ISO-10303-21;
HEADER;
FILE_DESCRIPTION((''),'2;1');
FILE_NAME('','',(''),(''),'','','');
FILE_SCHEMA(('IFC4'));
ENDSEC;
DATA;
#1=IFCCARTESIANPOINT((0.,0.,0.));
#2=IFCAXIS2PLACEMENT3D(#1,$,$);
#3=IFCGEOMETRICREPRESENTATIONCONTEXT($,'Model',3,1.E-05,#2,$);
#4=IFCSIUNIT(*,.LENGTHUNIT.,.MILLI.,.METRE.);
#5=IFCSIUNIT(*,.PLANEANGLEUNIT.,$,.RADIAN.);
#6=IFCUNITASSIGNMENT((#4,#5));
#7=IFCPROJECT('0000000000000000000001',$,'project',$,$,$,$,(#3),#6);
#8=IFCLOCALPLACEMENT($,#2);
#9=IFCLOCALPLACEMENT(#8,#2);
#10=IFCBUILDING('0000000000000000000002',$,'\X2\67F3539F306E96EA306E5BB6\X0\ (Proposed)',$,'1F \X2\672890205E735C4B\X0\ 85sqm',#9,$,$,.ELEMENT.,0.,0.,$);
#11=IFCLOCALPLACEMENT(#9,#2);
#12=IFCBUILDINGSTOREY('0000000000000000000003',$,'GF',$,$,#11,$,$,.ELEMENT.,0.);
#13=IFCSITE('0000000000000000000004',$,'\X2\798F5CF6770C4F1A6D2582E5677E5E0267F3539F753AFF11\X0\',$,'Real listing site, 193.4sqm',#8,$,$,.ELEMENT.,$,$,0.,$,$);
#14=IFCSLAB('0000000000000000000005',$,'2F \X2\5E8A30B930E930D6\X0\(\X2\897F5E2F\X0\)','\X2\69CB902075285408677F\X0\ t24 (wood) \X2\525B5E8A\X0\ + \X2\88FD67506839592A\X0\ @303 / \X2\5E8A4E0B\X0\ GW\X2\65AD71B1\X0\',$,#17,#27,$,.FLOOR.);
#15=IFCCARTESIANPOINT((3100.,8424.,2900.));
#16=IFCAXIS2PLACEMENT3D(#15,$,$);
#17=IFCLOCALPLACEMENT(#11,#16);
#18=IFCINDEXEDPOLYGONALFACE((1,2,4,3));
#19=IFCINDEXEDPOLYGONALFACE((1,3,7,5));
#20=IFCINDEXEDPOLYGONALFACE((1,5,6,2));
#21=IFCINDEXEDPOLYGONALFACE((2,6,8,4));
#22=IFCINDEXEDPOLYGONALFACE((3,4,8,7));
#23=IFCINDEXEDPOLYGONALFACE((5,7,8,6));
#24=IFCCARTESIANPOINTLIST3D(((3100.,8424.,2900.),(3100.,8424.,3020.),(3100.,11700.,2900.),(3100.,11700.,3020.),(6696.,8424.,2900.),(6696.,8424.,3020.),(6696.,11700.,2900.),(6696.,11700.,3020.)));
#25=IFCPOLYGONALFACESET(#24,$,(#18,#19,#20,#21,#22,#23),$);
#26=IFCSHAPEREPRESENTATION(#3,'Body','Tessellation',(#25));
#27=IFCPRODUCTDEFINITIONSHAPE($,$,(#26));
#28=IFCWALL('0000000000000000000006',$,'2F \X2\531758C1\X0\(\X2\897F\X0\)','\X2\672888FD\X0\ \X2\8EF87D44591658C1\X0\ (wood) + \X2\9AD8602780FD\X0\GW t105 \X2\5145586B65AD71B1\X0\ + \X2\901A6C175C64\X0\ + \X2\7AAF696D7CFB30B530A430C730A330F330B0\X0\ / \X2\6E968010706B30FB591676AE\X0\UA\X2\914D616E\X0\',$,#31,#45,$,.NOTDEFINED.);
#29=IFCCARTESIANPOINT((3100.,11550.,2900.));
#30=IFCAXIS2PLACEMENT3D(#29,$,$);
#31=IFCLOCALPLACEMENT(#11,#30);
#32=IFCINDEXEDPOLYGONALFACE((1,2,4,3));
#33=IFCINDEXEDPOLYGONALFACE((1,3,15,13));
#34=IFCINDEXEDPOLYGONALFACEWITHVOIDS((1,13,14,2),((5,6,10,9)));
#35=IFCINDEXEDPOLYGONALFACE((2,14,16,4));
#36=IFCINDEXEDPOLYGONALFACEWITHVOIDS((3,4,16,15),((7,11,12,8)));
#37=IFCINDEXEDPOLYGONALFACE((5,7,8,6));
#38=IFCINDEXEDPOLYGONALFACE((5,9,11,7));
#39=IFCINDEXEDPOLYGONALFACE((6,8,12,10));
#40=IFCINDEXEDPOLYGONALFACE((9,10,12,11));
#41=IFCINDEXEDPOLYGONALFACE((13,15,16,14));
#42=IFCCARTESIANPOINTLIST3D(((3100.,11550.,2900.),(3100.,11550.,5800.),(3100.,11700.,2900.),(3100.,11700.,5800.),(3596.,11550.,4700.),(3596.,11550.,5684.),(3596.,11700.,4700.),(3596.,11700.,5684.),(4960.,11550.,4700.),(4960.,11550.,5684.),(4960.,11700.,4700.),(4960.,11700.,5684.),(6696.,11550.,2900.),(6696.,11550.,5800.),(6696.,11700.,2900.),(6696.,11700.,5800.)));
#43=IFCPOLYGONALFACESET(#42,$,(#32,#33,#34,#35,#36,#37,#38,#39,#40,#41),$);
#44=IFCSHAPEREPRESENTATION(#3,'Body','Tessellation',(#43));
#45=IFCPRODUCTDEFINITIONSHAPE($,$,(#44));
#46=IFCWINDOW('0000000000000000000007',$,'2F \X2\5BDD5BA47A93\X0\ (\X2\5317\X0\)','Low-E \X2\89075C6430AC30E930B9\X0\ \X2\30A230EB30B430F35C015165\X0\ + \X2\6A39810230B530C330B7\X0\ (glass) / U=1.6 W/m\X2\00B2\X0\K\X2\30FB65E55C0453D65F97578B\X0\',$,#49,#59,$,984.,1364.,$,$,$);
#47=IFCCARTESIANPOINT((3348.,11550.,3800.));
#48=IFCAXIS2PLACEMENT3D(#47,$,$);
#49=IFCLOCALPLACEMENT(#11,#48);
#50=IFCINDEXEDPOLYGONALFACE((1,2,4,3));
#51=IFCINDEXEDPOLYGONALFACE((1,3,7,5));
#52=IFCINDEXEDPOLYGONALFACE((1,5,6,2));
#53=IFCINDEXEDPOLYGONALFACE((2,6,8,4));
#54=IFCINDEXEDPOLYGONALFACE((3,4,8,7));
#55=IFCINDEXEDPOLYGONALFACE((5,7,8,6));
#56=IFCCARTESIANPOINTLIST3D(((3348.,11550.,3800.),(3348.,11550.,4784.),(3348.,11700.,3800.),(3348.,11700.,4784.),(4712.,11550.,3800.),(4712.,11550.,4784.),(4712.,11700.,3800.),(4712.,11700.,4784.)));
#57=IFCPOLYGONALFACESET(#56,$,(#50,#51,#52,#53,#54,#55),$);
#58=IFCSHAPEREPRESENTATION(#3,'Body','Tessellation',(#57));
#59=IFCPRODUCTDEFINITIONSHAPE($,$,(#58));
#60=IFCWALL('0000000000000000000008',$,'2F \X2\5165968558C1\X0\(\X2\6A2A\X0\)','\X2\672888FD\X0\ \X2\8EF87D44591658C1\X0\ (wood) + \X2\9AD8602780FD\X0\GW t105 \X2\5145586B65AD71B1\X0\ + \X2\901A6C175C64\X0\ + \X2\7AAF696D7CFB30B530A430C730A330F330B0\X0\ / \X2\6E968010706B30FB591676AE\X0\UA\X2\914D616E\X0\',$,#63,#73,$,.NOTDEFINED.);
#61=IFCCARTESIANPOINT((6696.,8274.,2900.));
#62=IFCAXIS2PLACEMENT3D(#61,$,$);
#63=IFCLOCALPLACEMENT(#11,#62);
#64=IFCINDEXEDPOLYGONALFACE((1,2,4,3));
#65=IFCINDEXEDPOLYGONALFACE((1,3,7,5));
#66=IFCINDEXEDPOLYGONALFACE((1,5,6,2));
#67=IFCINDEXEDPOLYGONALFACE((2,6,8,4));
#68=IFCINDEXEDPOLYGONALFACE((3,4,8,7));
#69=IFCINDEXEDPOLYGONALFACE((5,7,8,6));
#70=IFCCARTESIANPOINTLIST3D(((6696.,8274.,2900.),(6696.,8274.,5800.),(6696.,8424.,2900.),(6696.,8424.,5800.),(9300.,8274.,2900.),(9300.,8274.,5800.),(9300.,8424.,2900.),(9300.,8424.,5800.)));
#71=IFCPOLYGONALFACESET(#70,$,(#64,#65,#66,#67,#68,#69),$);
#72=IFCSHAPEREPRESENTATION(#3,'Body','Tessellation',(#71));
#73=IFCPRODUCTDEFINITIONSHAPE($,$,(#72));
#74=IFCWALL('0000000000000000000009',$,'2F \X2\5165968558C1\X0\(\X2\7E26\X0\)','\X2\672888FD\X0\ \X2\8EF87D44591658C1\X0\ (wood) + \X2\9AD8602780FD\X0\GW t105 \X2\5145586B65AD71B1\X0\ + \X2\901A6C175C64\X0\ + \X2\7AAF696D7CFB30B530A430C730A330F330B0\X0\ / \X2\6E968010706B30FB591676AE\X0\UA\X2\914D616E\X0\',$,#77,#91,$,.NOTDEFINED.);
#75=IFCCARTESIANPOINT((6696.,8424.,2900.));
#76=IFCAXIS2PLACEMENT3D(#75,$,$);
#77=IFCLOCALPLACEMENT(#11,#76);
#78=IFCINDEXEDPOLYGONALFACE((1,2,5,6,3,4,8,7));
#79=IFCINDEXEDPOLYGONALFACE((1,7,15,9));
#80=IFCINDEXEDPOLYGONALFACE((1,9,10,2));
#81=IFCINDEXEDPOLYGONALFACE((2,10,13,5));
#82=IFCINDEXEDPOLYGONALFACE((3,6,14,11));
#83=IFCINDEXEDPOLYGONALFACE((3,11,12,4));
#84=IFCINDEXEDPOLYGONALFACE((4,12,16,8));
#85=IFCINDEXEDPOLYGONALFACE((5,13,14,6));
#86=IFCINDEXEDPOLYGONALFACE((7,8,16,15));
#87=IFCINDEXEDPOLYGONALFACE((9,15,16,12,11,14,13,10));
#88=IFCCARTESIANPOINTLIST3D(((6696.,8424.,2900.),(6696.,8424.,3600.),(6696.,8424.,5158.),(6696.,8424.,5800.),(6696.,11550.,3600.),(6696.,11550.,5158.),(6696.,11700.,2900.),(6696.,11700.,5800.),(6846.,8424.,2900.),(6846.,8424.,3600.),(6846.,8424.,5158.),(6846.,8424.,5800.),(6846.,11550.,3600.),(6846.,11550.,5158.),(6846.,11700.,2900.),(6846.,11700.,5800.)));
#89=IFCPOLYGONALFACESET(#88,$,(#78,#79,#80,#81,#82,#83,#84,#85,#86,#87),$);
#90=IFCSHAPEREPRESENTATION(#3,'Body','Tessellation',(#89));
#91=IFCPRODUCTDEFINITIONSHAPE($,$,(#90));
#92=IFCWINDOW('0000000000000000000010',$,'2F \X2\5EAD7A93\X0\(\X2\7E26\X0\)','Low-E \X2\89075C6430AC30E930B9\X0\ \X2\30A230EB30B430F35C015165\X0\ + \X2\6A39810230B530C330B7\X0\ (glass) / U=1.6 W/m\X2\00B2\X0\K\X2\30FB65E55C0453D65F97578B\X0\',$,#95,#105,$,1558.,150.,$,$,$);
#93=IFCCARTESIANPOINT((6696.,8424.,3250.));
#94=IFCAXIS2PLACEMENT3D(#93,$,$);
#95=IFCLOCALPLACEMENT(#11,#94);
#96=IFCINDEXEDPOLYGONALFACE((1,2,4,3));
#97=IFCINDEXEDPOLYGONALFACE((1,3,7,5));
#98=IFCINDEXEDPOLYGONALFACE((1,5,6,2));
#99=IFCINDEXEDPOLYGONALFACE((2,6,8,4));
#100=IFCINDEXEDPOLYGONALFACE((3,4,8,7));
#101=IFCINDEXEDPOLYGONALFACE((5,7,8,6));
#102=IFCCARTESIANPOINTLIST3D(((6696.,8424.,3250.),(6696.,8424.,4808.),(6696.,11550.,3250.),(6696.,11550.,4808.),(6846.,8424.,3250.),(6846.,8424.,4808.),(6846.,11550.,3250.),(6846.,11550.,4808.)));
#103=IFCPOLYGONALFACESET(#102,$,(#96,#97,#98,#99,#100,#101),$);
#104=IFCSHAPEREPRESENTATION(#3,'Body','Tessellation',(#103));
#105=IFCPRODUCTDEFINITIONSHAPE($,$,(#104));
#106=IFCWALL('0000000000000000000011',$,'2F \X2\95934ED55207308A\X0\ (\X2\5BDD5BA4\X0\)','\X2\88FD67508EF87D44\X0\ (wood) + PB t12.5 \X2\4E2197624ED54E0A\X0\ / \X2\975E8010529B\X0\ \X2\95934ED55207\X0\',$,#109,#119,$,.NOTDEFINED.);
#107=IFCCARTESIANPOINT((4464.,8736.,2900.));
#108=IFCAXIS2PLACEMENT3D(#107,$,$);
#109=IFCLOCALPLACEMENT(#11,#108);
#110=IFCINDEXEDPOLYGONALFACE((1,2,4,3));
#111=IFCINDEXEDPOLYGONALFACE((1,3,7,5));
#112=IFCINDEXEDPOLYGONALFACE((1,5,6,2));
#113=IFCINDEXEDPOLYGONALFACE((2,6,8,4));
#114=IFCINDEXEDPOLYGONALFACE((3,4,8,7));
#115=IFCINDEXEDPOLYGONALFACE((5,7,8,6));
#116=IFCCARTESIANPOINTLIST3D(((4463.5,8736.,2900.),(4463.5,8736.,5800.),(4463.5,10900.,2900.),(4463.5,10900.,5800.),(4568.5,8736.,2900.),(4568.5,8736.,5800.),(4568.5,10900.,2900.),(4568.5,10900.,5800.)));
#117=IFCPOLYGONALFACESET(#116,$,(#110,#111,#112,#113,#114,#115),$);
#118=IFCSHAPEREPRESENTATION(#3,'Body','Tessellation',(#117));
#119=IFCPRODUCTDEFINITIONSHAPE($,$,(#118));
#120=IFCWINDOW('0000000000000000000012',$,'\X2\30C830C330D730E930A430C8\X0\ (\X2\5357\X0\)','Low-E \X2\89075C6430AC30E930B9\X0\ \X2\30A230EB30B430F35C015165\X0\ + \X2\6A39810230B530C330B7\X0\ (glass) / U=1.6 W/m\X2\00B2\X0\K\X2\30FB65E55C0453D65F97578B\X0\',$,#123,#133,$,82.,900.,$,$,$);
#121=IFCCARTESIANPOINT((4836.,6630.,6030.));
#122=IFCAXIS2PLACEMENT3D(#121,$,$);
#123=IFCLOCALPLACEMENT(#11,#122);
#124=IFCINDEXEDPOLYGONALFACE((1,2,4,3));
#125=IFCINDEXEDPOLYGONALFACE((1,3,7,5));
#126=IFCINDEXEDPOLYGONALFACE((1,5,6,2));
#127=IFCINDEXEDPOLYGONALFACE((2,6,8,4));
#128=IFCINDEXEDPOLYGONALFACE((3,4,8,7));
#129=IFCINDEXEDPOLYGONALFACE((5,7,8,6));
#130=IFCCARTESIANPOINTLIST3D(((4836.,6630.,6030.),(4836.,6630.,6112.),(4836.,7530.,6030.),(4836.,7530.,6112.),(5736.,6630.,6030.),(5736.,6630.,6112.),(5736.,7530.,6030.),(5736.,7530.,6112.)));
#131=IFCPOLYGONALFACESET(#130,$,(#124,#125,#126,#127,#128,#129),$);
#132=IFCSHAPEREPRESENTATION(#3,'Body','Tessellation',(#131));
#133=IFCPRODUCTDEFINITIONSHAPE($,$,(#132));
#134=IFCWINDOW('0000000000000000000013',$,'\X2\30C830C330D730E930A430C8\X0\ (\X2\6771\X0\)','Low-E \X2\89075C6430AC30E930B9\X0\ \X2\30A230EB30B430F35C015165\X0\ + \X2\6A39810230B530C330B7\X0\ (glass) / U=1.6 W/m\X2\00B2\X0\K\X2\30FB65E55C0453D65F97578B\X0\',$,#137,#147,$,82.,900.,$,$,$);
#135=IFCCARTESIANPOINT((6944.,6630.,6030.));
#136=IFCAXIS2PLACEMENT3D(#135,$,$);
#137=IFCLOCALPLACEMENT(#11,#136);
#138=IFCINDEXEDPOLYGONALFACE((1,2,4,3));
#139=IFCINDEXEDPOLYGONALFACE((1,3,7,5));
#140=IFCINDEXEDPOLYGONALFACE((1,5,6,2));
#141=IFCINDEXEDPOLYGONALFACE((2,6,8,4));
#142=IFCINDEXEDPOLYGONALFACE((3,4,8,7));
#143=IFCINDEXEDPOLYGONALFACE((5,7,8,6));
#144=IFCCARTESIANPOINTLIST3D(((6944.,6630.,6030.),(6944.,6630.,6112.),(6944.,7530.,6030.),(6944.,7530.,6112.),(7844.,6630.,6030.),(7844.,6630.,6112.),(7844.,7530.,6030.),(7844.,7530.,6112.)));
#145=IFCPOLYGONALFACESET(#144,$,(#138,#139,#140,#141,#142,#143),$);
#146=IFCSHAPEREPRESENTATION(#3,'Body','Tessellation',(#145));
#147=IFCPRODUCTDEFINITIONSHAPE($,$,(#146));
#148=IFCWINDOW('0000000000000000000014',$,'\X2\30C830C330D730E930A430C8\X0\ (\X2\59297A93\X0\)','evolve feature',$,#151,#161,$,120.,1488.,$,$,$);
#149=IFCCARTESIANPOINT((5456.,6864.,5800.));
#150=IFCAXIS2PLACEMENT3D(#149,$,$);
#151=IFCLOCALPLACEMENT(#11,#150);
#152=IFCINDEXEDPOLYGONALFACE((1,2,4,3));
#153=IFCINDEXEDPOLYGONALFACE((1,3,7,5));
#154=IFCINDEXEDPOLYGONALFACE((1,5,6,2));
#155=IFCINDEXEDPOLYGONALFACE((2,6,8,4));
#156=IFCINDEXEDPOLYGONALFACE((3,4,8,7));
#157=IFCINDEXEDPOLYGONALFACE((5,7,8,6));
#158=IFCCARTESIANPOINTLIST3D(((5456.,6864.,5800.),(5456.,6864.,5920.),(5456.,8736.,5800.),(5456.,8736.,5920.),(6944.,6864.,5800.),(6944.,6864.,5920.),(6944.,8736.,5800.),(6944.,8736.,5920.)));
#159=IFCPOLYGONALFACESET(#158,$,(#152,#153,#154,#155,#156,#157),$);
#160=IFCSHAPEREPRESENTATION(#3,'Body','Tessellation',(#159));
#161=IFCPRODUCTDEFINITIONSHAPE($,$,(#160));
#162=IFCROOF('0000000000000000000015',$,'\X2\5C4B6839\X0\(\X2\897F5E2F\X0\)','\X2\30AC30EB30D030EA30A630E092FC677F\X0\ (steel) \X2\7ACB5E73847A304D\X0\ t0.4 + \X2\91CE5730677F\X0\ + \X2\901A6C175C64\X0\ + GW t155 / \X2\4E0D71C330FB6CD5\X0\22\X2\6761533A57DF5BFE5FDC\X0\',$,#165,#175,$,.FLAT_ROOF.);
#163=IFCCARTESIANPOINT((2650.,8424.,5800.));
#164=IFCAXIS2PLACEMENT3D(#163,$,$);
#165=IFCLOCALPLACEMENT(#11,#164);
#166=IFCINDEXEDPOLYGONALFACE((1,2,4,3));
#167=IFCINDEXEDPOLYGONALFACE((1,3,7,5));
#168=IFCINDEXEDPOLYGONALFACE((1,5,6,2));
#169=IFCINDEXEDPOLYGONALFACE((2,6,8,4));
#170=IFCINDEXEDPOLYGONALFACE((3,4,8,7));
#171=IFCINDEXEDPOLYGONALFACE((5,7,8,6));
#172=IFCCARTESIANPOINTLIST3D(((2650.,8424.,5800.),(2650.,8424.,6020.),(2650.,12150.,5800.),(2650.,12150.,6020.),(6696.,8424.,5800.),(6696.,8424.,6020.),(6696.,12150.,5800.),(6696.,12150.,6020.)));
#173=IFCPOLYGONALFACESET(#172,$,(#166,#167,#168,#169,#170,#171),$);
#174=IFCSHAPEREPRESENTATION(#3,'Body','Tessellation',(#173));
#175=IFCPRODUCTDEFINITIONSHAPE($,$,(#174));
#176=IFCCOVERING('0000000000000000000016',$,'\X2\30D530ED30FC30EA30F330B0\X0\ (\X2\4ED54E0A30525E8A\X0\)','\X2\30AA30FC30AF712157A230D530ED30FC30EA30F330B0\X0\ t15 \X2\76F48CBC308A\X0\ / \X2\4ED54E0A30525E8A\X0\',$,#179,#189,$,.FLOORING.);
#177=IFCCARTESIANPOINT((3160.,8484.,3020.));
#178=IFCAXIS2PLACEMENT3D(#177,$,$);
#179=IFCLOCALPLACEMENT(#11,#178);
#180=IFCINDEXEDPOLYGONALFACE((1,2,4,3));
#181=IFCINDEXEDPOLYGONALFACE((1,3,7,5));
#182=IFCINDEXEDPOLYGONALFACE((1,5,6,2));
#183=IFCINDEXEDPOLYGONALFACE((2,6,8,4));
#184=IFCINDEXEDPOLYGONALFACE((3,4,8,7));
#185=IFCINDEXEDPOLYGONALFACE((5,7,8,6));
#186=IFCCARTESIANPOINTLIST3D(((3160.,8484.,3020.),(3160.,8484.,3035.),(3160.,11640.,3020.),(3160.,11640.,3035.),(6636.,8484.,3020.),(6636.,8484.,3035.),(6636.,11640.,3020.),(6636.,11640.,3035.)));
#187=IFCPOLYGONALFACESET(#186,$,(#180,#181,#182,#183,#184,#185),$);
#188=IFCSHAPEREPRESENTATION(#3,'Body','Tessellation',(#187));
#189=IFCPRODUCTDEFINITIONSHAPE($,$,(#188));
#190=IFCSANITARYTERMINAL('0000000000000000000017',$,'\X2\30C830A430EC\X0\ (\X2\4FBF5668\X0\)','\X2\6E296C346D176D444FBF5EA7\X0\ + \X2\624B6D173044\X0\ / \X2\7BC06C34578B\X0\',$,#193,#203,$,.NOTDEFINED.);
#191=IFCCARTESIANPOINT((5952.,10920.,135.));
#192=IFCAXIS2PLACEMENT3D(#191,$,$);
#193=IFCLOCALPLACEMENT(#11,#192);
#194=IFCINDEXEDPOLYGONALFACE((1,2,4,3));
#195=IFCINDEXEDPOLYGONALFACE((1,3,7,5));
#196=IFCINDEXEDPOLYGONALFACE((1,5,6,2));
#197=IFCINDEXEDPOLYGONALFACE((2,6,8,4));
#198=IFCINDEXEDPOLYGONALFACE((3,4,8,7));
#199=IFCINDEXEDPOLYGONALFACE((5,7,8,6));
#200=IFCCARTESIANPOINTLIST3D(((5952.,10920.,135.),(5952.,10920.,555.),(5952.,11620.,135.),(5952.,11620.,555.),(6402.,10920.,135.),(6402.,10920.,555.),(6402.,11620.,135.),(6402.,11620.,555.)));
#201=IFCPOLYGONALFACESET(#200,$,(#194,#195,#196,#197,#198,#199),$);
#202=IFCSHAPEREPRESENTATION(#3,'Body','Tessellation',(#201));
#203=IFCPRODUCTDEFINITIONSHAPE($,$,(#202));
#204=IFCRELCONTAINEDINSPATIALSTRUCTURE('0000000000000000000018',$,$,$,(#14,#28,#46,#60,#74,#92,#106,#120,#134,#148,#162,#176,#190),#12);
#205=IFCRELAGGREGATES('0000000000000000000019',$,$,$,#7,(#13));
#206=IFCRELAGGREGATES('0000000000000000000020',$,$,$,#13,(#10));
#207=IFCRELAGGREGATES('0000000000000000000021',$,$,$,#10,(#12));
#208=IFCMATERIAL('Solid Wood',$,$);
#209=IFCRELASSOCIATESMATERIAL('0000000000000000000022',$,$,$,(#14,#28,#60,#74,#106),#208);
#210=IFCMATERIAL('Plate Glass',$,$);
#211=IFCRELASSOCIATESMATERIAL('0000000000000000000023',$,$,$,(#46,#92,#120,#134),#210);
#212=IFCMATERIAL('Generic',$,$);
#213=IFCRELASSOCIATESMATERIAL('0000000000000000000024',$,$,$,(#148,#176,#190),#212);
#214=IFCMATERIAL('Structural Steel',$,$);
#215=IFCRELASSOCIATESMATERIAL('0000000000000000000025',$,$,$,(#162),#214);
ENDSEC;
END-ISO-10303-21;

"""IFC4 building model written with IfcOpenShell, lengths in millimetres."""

from ifc_helpers import new_model, si_unit, frame, frame_2d, origin, place, context, project, spatial, rectangle, extrude, material, element, fill, save


model = new_model("IFC4")

# Units and contexts
model_context = context("Model", 3, precision=1e-05, world=origin())
ifc_project = project(units=[si_unit("LENGTHUNIT", "METRE", prefix="MILLI"), si_unit("PLANEANGLEUNIT", "RADIAN")], contexts=[model_context])

# Site, building, storey
site_placement = place(None, origin())
site = spatial("IfcSite", under=ifc_project, at=site_placement, Name="福島県会津若松市柳原町１", ObjectType="Real listing site, 193.4sqm", CompositionType="ELEMENT", RefElevation=0.0)
building_placement = place(site_placement, origin())
building = spatial("IfcBuilding", under=site, at=building_placement, Name="柳原の雪の家 (Proposed)", ObjectType="1F 木造平屋 85sqm", CompositionType="ELEMENT", ElevationOfRefHeight=0.0, ElevationOfTerrain=0.0)
storey_placement = place(building_placement, origin())
storey = spatial("IfcBuildingStorey", under=building, at=storey_placement, Name="GF", CompositionType="ELEMENT", Elevation=0.0)

# Slab
ifc_material_1 = material(Name="Solid Wood")
slab_placement = place(storey_placement, frame((3100.0, 8424.0, 2900.0)))
element("IfcSlab", 1, at=slab_placement, inside=storey, material=ifc_material_1, Name="2F 床スラブ(西帯)", Description="構造用合板 t24 (wood) 剛床 + 製材根太 @303 / 床下 GW断熱", PredefinedType="FLOOR", context=model_context, shape_type="SweptSolid", body=[
    extrude(rectangle(XDim=3596.0, YDim=3276.0, at=frame_2d((1798.0, 1638.0))), frame((3100.0, 8424.0, 2900.0)), (0.0, 0.0, 1.0), 120.0),
])

# Wall, opening, window
wall_1_placement = place(storey_placement, frame((3100.0, 11550.0, 2900.0)))
wall_1 = element("IfcWall", 2, at=wall_1_placement, inside=storey, material=ifc_material_1, Name="2F 北壁(西)", Description="木製 軸組外壁 (wood) + 高性能GW t105 充填断熱 + 通気層 + 窯業系サイディング / 準耐火・外皮UA配慮", PredefinedType="NOTDEFINED", context=model_context, shape_type="SweptSolid", body=[
    extrude(rectangle(XDim=3596.0, YDim=150.0, at=frame_2d((1798.0, 75.0))), frame((3100.0, 11550.0, 2900.0)), (0.0, 0.0, 1.0), 2900.0),
])
opening_1_placement = place(storey_placement, frame((3348.0, 11550.0, 3800.0)))
opening_1 = element("IfcOpeningElement", 3, at=opening_1_placement, cuts=wall_1, PredefinedType="NOTDEFINED", context=model_context, shape_type="SweptSolid", body=[
    extrude(rectangle(XDim=1364.0, YDim=150.0, at=frame_2d((682.0, 75.0))), frame((3348.0, 11550.0, 3800.0)), (0.0, 0.0, 1.0), 984.0),
])
ifc_material_2 = material(Name="Plate Glass")
window_1_placement = place(storey_placement, frame((3348.0, 11550.0, 3800.0)))
window_1 = element("IfcWindow", 4, at=window_1_placement, inside=storey, material=ifc_material_2, Name="2F 寝室窓 (北)", Description="Low-E 複層ガラス アルゴン封入 + 樹脂サッシ (glass) / U=1.6 W/m²K・日射取得型", OverallHeight=984.0, OverallWidth=1364.0, context=model_context, shape_type="SweptSolid", body=[
    extrude(rectangle(XDim=1364.0, YDim=150.0, at=frame_2d((682.0, 75.0))), frame((3348.0, 11550.0, 3800.0)), (0.0, 0.0, 1.0), 984.0),
])
fill(opening_1, window_1)

# Wall
wall_2_placement = place(storey_placement, frame((6696.0, 8274.0, 2900.0)))
element("IfcWall", 5, at=wall_2_placement, inside=storey, material=ifc_material_1, Name="2F 入隅壁(横)", Description="木製 軸組外壁 (wood) + 高性能GW t105 充填断熱 + 通気層 + 窯業系サイディング / 準耐火・外皮UA配慮", PredefinedType="NOTDEFINED", context=model_context, shape_type="SweptSolid", body=[
    extrude(rectangle(XDim=2604.0, YDim=150.0, at=frame_2d((1302.0, 75.0))), frame((6696.0, 8274.0, 2900.0)), (0.0, 0.0, 1.0), 2900.0),
])

# Wall, opening, window
wall_3_placement = place(storey_placement, frame((6696.0, 8424.0, 2900.0)))
wall_3 = element("IfcWall", 6, at=wall_3_placement, inside=storey, material=ifc_material_1, Name="2F 入隅壁(縦)", Description="木製 軸組外壁 (wood) + 高性能GW t105 充填断熱 + 通気層 + 窯業系サイディング / 準耐火・外皮UA配慮", PredefinedType="NOTDEFINED", context=model_context, shape_type="SweptSolid", body=[
    extrude(rectangle(XDim=150.0, YDim=3276.0, at=frame_2d((75.0, 1638.0))), frame((6696.0, 8424.0, 2900.0)), (0.0, 0.0, 1.0), 2900.0),
])
opening_2_placement = place(storey_placement, frame((6696.0, 8424.0, 3250.0)))
opening_2 = element("IfcOpeningElement", 7, at=opening_2_placement, cuts=wall_3, PredefinedType="NOTDEFINED", context=model_context, shape_type="SweptSolid", body=[
    extrude(rectangle(XDim=150.0, YDim=3126.0, at=frame_2d((75.0, 1563.0))), frame((6696.0, 8424.0, 3250.0)), (0.0, 0.0, 1.0), 1558.0),
])
window_2_placement = place(storey_placement, frame((6696.0, 8424.0, 3250.0)))
window_2 = element("IfcWindow", 8, at=window_2_placement, inside=storey, material=ifc_material_2, Name="2F 庭窓(縦)", Description="Low-E 複層ガラス アルゴン封入 + 樹脂サッシ (glass) / U=1.6 W/m²K・日射取得型", OverallHeight=1558.0, OverallWidth=150.0, context=model_context, shape_type="SweptSolid", body=[
    extrude(rectangle(XDim=150.0, YDim=3126.0, at=frame_2d((75.0, 1563.0))), frame((6696.0, 8424.0, 3250.0)), (0.0, 0.0, 1.0), 1558.0),
])
fill(opening_2, window_2)

# Wall
wall_4_placement = place(storey_placement, frame((4464.0, 8736.0, 2900.0)))
element("IfcWall", 9, at=wall_4_placement, inside=storey, material=ifc_material_1, Name="2F 間仕切り (寝室)", Description="製材軸組 (wood) + PB t12.5 両面仕上 / 非耐力 間仕切", PredefinedType="NOTDEFINED", context=model_context, shape_type="SweptSolid", body=[
    extrude(rectangle(XDim=105.0, YDim=2164.0, at=frame_2d((52.0, 1082.0))), frame((4464.0, 8736.0, 2900.0)), (0.0, 0.0, 1.0), 2900.0),
])

# Windows
window_3_placement = place(storey_placement, frame((4836.0, 6630.0, 6030.0)))
element("IfcWindow", 10, at=window_3_placement, inside=storey, material=ifc_material_2, Name="トップライト (南)", Description="Low-E 複層ガラス アルゴン封入 + 樹脂サッシ (glass) / U=1.6 W/m²K・日射取得型", OverallHeight=82.0, OverallWidth=900.0, context=model_context, shape_type="SweptSolid", body=[
    extrude(rectangle(XDim=900.0, YDim=900.0, at=frame_2d((450.0, 450.0))), frame((4836.0, 6630.0, 6030.0)), (0.0, 0.0, 1.0), 82.0),
])
window_4_placement = place(storey_placement, frame((6944.0, 6630.0, 6030.0)))
element("IfcWindow", 11, at=window_4_placement, inside=storey, material=ifc_material_2, Name="トップライト (東)", Description="Low-E 複層ガラス アルゴン封入 + 樹脂サッシ (glass) / U=1.6 W/m²K・日射取得型", OverallHeight=82.0, OverallWidth=900.0, context=model_context, shape_type="SweptSolid", body=[
    extrude(rectangle(XDim=900.0, YDim=900.0, at=frame_2d((450.0, 450.0))), frame((6944.0, 6630.0, 6030.0)), (0.0, 0.0, 1.0), 82.0),
])
ifc_material_3 = material(Name="Generic")
window_5_placement = place(storey_placement, frame((5456.0, 6864.0, 5800.0)))
element("IfcWindow", 12, at=window_5_placement, inside=storey, material=ifc_material_3, Name="トップライト (天窓)", Description="evolve feature", OverallHeight=120.0, OverallWidth=1488.0, context=model_context, shape_type="SweptSolid", body=[
    extrude(rectangle(XDim=1488.0, YDim=1872.0, at=frame_2d((744.0, 936.0))), frame((5456.0, 6864.0, 5800.0)), (0.0, 0.0, 1.0), 120.0),
])

# Roof
ifc_material_4 = material(Name="Structural Steel")
for number, where, name in (
    (13, (2650.0, 8424.0, 5800.0), "屋根(西帯)"),
):
    element("IfcRoof", number, at=place(storey_placement, frame(where)), inside=storey, material=ifc_material_4, Name=name, Description="ガルバリウム鋼板 (steel) 立平葺き t0.4 + 野地板 + 通気層 + GW t155 / 不燃・法22条区域対応", PredefinedType="FLAT_ROOF", context=model_context, shape_type="SweptSolid", body=[
        extrude(rectangle(XDim=4046.0, YDim=3726.0, at=frame_2d((2023.0, 1863.0))), frame((2650.0, 8424.0, 5800.0)), (0.0, 0.0, 1.0), 220.0),
    ])

# Covering
covering_placement = place(storey_placement, frame((3160.0, 8484.0, 3020.0)))
element("IfcCovering", 14, at=covering_placement, inside=storey, material=ifc_material_3, Name="フローリング (仕上げ床)", Description="オーク無垢フローリング t15 直貼り / 仕上げ床", PredefinedType="FLOORING", context=model_context, shape_type="SweptSolid", body=[
    extrude(rectangle(XDim=3476.0, YDim=3156.0, at=frame_2d((1738.0, 1578.0))), frame((3160.0, 8484.0, 3020.0)), (0.0, 0.0, 1.0), 15.0),
])

# Sanitary terminal
sanitary_terminal_placement = place(storey_placement, frame((5952.0, 10920.0, 135.0)))
element("IfcSanitaryTerminal", 15, at=sanitary_terminal_placement, inside=storey, material=ifc_material_3, Name="トイレ (便器)", Description="温水洗浄便座 + 手洗い / 節水型", PredefinedType="NOTDEFINED", context=model_context, shape_type="SweptSolid", body=[
    extrude(rectangle(XDim=450.0, YDim=700.0, at=frame_2d((225.0, 350.0))), frame((5952.0, 10920.0, 135.0)), (0.0, 0.0, 1.0), 420.0),
])

save(model, "model.ifc")
